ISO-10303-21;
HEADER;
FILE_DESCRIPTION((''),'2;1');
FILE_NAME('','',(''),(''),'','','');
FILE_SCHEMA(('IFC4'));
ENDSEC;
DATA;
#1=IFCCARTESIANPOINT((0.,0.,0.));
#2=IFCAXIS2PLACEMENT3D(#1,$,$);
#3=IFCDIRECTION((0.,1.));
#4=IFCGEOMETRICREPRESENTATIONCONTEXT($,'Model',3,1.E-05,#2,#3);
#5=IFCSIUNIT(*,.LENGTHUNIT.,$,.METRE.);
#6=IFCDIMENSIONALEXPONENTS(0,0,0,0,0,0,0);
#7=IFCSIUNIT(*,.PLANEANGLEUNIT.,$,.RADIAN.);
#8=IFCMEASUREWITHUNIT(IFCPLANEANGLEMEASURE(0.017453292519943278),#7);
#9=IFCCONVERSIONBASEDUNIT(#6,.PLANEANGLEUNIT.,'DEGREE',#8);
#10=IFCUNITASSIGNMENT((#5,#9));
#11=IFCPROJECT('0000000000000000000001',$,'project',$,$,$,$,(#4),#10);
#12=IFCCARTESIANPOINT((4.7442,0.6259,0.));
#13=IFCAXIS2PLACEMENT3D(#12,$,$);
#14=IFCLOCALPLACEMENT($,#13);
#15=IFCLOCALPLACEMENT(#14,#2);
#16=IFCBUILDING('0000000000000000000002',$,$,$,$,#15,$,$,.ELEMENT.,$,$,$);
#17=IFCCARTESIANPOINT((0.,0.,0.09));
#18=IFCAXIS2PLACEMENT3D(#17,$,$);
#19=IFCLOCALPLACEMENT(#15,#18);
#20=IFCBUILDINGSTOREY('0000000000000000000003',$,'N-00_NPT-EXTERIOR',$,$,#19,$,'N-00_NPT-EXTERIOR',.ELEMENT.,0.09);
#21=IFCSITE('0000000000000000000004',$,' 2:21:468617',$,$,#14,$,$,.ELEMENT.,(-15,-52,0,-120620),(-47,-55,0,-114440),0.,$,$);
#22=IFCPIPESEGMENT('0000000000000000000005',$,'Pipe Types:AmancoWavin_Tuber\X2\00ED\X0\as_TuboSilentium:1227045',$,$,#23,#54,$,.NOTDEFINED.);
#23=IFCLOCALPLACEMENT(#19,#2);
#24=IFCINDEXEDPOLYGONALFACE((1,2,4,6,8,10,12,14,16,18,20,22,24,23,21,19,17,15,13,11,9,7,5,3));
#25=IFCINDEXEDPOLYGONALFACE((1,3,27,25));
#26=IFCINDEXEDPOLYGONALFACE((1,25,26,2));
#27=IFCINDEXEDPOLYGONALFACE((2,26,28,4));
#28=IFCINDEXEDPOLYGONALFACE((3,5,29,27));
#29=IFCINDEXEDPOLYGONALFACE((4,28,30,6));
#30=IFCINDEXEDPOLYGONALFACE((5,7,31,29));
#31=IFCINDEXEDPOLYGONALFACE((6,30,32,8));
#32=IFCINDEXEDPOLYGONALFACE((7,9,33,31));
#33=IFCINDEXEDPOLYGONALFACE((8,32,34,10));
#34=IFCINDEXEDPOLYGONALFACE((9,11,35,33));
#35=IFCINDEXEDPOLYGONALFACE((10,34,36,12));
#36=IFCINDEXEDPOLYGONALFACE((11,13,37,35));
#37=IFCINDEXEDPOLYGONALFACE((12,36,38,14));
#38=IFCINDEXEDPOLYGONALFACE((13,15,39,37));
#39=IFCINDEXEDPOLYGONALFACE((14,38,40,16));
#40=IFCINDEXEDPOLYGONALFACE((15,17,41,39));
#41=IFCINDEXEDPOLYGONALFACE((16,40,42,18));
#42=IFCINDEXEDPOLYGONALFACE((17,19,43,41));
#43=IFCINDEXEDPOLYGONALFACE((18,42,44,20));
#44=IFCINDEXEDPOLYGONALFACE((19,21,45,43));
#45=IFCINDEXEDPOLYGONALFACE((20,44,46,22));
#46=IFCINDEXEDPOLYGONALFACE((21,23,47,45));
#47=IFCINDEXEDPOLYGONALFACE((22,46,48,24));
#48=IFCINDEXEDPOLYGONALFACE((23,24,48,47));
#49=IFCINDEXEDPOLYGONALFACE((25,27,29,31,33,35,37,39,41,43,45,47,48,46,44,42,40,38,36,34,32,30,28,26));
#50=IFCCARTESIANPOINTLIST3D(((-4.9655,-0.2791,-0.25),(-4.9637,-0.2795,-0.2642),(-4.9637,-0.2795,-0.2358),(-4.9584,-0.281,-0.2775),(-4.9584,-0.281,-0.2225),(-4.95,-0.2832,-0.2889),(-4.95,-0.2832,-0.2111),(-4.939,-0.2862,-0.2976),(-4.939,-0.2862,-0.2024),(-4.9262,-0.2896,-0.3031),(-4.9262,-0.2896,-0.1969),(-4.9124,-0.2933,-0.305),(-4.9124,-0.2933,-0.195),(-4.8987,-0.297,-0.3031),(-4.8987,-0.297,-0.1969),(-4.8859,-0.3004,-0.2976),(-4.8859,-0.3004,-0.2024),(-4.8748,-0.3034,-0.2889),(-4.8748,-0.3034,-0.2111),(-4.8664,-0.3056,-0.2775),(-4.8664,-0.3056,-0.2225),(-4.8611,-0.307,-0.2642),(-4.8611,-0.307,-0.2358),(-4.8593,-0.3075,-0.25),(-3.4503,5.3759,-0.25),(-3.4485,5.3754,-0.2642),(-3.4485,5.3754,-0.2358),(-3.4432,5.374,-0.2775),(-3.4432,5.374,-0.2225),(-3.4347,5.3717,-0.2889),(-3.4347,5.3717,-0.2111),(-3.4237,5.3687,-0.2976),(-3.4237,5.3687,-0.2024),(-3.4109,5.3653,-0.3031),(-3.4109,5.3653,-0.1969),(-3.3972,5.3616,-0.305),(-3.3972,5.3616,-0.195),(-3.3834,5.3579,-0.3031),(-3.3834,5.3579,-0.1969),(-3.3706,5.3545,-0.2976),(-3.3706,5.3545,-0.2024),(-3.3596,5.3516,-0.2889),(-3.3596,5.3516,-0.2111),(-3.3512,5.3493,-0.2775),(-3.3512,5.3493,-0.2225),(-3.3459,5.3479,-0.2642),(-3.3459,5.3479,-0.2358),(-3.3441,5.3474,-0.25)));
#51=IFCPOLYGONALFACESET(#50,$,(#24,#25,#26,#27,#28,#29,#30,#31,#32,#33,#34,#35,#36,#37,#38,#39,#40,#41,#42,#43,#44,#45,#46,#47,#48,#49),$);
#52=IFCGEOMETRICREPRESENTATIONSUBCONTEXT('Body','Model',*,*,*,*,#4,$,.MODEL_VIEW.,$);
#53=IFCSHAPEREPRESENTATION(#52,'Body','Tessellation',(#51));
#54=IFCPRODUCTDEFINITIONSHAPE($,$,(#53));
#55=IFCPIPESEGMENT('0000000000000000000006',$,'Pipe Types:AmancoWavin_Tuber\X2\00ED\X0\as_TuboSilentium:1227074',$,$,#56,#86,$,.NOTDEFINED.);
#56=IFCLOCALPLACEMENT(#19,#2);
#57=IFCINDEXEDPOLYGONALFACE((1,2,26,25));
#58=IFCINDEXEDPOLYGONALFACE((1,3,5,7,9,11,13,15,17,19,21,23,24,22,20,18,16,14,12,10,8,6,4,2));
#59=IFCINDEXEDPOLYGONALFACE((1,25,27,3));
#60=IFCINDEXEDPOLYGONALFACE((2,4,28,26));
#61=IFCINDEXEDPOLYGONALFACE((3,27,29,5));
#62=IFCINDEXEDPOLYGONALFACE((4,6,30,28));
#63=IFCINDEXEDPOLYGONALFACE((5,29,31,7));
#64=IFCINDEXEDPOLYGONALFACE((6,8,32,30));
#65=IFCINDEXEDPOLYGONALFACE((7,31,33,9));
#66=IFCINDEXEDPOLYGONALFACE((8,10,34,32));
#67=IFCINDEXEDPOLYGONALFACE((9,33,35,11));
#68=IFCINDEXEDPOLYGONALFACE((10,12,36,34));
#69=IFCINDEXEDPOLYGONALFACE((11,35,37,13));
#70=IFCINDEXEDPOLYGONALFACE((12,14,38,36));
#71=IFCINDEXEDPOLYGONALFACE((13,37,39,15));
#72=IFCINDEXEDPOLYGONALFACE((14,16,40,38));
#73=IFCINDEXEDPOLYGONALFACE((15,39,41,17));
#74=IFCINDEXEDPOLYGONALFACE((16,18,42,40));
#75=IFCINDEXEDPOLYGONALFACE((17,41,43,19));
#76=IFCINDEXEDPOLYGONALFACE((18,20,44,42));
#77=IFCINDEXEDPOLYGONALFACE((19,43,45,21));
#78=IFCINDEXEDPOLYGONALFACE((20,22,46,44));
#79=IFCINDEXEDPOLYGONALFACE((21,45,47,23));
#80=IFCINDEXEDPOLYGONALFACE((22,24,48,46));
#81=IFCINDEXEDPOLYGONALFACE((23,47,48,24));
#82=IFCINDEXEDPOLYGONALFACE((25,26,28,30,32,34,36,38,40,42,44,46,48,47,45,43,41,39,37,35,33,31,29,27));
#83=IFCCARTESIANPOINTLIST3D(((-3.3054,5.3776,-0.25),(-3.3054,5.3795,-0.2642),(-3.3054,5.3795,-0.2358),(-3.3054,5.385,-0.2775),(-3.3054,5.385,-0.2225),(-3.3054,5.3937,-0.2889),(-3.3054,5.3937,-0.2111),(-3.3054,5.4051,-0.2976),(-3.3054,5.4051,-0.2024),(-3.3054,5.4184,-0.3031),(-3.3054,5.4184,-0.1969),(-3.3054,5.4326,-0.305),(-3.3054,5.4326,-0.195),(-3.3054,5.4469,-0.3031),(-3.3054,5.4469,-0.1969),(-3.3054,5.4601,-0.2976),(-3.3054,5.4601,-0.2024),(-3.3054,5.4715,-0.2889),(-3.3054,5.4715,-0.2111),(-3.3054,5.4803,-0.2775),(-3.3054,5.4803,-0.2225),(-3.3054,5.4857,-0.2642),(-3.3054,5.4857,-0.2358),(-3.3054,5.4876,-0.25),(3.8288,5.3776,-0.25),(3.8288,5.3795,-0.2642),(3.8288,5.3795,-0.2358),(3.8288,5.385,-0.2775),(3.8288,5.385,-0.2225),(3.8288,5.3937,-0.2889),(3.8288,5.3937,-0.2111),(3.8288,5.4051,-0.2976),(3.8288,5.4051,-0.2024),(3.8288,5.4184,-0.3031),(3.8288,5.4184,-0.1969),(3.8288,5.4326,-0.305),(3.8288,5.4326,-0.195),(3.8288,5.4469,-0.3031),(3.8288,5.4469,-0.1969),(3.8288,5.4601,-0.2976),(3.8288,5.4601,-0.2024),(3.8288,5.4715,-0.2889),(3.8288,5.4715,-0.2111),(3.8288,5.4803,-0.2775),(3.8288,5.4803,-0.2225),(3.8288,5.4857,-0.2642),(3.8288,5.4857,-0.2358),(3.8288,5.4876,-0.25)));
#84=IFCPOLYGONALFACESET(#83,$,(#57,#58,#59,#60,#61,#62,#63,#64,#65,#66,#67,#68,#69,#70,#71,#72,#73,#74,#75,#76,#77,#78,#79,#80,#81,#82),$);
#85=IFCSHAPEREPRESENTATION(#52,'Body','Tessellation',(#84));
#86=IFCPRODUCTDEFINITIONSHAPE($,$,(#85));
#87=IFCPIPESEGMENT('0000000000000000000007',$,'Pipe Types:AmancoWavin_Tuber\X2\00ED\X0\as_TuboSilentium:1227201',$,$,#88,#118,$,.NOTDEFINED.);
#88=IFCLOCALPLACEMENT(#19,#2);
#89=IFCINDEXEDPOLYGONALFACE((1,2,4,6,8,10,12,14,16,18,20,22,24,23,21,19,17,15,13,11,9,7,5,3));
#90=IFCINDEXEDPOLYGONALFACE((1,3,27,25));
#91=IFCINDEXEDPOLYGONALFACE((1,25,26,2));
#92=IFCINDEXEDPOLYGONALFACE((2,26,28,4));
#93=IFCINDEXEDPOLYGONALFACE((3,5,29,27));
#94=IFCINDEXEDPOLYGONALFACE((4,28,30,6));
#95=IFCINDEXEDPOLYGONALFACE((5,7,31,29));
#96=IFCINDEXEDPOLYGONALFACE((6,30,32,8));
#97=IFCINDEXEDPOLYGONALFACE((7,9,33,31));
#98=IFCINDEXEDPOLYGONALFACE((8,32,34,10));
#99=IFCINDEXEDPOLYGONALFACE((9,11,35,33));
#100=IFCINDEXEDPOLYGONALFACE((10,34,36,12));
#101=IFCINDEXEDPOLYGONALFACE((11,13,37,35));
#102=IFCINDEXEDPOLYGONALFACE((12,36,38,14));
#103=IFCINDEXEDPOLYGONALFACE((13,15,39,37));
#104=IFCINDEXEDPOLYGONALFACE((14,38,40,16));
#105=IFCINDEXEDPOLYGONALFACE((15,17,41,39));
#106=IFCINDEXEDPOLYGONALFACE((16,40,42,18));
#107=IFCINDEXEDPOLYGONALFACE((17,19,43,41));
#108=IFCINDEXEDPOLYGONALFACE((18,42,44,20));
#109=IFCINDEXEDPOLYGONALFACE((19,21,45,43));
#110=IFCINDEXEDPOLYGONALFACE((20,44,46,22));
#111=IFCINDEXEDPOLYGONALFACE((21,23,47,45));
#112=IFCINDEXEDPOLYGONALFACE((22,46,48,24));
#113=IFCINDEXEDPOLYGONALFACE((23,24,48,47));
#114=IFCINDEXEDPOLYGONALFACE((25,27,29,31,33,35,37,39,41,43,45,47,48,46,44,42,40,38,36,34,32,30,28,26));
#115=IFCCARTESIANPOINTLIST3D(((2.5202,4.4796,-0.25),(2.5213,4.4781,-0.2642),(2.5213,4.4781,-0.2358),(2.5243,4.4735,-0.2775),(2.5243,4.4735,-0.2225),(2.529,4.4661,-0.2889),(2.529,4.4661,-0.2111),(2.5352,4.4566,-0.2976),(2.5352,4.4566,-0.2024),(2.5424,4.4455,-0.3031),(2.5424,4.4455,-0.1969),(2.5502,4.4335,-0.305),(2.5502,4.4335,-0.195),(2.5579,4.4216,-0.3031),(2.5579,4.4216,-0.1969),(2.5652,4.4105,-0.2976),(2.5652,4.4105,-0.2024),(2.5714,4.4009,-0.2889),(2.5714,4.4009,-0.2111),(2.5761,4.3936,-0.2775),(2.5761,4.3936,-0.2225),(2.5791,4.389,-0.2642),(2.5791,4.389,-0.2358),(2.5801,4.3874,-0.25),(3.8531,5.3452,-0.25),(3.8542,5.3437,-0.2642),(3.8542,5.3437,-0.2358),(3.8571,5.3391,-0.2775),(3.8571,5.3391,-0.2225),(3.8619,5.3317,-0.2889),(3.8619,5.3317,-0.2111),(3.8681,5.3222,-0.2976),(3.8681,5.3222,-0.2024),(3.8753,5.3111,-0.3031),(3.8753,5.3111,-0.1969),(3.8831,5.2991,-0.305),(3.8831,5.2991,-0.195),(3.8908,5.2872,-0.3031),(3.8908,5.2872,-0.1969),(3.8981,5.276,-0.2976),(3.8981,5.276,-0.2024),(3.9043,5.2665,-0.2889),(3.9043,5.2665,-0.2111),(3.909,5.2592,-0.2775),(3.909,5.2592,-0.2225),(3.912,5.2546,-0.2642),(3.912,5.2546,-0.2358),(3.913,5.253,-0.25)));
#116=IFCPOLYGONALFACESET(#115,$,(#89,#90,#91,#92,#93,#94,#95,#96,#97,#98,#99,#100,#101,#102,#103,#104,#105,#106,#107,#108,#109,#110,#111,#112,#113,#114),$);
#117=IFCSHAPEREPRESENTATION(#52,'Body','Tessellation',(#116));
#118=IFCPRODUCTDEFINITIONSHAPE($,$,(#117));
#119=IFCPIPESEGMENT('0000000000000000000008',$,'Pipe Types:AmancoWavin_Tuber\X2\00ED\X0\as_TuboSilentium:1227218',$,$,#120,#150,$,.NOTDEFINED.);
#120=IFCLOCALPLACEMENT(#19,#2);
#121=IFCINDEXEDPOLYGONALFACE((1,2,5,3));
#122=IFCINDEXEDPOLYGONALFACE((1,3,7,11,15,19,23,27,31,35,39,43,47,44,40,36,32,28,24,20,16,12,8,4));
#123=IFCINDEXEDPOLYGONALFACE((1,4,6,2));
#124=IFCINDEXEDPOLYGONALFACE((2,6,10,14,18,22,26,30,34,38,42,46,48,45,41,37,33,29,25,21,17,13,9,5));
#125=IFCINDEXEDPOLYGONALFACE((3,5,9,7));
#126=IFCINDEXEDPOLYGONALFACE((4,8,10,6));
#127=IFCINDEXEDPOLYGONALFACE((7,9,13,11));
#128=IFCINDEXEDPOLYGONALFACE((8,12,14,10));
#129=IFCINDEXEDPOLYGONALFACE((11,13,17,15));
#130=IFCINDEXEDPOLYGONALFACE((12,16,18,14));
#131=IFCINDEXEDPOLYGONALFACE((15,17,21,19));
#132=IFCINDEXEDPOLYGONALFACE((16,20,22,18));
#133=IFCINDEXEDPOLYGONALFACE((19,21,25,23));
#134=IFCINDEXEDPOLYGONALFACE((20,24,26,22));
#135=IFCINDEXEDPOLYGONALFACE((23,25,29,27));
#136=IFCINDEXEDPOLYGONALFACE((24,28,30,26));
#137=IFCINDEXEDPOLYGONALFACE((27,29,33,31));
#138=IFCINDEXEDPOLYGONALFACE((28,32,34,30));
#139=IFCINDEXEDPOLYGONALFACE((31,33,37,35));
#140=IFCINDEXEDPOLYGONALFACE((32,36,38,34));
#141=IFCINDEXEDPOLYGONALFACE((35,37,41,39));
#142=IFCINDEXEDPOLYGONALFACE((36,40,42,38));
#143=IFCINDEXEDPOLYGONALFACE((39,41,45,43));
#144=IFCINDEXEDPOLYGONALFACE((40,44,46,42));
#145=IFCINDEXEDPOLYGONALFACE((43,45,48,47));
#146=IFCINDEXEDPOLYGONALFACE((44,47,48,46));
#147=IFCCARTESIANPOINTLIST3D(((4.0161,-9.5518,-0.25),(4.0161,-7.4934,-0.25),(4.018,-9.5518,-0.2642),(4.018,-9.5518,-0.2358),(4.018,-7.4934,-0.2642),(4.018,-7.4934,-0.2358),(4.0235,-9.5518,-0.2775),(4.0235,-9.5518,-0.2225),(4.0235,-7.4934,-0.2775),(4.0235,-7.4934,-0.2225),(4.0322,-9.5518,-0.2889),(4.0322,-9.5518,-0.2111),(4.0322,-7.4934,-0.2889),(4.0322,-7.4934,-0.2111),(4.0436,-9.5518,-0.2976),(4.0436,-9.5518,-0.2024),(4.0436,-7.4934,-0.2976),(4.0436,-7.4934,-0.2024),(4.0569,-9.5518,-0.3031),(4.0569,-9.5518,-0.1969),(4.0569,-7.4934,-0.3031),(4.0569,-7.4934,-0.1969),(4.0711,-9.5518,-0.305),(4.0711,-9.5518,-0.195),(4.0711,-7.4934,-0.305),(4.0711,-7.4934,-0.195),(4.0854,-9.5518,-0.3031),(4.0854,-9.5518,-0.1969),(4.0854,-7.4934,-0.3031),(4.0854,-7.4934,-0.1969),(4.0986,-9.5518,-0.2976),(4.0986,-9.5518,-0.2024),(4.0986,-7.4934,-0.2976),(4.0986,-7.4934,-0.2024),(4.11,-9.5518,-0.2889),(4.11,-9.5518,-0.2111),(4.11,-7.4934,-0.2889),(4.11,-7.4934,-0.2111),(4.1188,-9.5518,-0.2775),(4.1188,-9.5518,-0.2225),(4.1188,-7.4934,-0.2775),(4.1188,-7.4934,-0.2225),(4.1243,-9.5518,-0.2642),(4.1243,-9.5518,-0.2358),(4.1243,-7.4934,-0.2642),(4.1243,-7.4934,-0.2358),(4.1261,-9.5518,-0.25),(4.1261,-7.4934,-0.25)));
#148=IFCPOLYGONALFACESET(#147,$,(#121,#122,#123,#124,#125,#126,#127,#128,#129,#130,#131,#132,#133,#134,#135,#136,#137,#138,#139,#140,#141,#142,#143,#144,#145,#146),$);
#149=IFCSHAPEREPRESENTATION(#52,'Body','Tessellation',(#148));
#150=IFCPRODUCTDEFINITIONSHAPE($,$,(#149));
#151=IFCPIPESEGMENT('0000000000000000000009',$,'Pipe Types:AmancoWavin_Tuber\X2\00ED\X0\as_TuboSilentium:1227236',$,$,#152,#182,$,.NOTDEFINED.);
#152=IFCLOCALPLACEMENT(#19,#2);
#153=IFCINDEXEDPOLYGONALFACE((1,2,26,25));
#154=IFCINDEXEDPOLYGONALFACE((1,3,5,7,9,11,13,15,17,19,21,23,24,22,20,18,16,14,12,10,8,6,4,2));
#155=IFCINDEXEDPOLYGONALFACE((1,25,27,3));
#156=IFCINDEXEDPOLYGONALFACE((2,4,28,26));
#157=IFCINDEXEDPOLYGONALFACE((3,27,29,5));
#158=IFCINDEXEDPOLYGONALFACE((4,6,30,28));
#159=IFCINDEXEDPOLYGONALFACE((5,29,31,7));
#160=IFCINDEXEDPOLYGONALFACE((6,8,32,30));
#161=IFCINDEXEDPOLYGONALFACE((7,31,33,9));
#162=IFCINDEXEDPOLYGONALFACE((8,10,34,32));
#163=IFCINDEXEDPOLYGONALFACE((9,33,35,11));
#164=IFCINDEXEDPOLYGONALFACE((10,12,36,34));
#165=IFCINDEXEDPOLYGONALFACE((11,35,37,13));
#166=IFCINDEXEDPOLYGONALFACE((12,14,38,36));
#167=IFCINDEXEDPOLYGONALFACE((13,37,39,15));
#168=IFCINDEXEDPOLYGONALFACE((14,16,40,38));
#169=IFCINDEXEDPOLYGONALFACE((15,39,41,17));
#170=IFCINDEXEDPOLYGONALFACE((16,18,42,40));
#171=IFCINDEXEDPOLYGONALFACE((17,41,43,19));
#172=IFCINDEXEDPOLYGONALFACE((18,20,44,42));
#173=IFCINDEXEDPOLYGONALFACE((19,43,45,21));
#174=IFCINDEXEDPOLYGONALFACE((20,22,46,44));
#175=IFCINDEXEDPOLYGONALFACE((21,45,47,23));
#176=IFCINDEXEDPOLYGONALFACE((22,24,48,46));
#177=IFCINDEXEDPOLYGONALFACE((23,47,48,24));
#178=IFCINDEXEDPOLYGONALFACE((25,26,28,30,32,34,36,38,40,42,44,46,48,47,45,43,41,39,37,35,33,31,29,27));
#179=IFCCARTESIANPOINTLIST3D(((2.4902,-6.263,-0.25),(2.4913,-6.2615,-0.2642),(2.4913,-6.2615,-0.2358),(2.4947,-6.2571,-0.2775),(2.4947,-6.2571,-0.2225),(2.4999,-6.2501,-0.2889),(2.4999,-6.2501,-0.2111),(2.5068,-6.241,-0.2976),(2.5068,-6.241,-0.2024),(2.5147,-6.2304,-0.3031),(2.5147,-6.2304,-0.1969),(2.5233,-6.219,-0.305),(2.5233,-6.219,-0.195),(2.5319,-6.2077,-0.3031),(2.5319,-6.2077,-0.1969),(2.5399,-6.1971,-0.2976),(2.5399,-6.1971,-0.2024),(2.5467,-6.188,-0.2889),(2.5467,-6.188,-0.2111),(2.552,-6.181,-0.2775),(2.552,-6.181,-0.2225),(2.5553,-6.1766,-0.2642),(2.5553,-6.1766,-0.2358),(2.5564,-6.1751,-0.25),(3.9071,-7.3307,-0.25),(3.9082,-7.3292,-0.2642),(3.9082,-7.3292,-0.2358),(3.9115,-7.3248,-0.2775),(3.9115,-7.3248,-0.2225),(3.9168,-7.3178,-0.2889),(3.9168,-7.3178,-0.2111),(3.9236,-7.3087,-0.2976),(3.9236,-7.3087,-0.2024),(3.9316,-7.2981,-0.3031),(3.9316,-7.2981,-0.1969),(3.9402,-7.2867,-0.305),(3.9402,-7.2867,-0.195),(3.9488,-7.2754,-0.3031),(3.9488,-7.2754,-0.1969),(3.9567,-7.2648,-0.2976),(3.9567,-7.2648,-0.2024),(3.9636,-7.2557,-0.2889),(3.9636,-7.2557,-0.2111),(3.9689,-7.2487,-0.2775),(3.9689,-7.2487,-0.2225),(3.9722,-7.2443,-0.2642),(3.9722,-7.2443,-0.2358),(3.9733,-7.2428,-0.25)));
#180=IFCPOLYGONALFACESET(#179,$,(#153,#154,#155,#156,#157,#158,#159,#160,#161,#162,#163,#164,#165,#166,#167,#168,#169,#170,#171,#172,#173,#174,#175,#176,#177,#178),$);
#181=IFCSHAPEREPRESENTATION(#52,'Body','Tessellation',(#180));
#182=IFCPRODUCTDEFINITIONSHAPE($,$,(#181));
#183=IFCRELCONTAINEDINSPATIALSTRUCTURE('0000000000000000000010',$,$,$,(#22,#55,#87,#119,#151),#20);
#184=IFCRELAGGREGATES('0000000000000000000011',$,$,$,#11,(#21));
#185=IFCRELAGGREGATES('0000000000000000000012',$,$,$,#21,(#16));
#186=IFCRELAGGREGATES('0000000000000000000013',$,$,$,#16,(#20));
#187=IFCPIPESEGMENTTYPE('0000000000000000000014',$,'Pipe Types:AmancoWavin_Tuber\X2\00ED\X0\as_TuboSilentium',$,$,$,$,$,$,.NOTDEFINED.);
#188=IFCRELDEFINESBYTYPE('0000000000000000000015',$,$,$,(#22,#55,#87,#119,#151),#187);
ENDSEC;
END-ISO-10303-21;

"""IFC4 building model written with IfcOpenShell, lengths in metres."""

from ifc_helpers import new_model, entity, si_unit, converted_unit, direction, frame, origin, place, context, subcontext, project, spatial, arc, indexed_curve, outline, extrude, type_object, element, save


model = new_model("IFC4")

# Units and contexts
model_context = context("Model", 3, precision=1e-05, world=origin(), true_north=direction((0.0, 1.0)))
body_context = subcontext(model_context, "Body", "Model", "MODEL_VIEW")
ifc_project = project(units=[si_unit("LENGTHUNIT", "METRE"), converted_unit("PLANEANGLEUNIT", "DEGREE", entity("IfcPlaneAngleMeasure", 0.017453292519943278), si_unit("PLANEANGLEUNIT", "RADIAN"), dimensions=[0, 0, 0, 0, 0, 0, 0])], contexts=[model_context])

# Site, building, storey
site_placement = place(None, frame((4.7442, 0.6259, 0.0)))
site = spatial("IfcSite", under=ifc_project, at=site_placement, Name=" 2:21:468617", CompositionType="ELEMENT", RefLatitude=(-15, -52, 0, -120620), RefLongitude=(-47, -55, 0, -114440), RefElevation=0.0)
building_placement = place(site_placement, origin())
building = spatial("IfcBuilding", under=site, at=building_placement, CompositionType="ELEMENT")
storey_placement = place(building_placement, frame((0.0, 0.0, 0.09)))
storey = spatial("IfcBuildingStorey", under=building, at=storey_placement, Name="N-00_NPT-EXTERIOR", LongName="N-00_NPT-EXTERIOR", CompositionType="ELEMENT", Elevation=0.09)

# Pipe segments
pipe_segment_type_1 = type_object("IfcPipeSegmentType", Name="Pipe Types:AmancoWavin_Tuberías_TuboSilentium", PredefinedType="NOTDEFINED")
pipe_segment_1_placement = place(storey_placement, origin())
element("IfcPipeSegment", 1, at=pipe_segment_1_placement, inside=storey, type_object=pipe_segment_type_1, Name="Pipe Types:AmancoWavin_Tuberías_TuboSilentium:1227045", PredefinedType="NOTDEFINED", context=body_context, shape_type="SweptSolid", body=[
    extrude(outline(indexed_curve([(0.055, 0.0), (0.0389, 0.0389), (0.0, 0.055), (-0.0389, 0.0389), (-0.055, 0.0), (-0.0389, -0.0389), (0.0, -0.055), (0.0389, -0.0389)], segments=[arc(1, 2, 3), arc(3, 4, 5), arc(5, 6, 7), arc(7, 8, 1)], self_intersect=False)), frame((-4.9124, -0.2933, -0.25), z_axis=(0.258819, 0.965926, 0.0), x_axis=(0.965926, -0.258819, 0.0)), (0.0, 0.0, 1.0), 5.8544),
])
pipe_segment_2_placement = place(storey_placement, origin())
element("IfcPipeSegment", 2, at=pipe_segment_2_placement, inside=storey, type_object=pipe_segment_type_1, Name="Pipe Types:AmancoWavin_Tuberías_TuboSilentium:1227074", PredefinedType="NOTDEFINED", context=body_context, shape_type="SweptSolid", body=[
    extrude(outline(indexed_curve([(0.055, 0.0), (0.0389, 0.0389), (0.0, 0.055), (-0.0389, 0.0389), (-0.055, 0.0), (-0.0389, -0.0389), (0.0, -0.055), (0.0389, -0.0389)], segments=[arc(1, 2, 3), arc(3, 4, 5), arc(5, 6, 7), arc(7, 8, 1)], self_intersect=False)), frame((-3.3054, 5.4326, -0.25), z_axis=(1.0, 0.0, 0.0), x_axis=(0.0, -1.0, 0.0)), (0.0, 0.0, 1.0), 7.1342),
])
pipe_segment_3_placement = place(storey_placement, origin())
element("IfcPipeSegment", 3, at=pipe_segment_3_placement, inside=storey, type_object=pipe_segment_type_1, Name="Pipe Types:AmancoWavin_Tuberías_TuboSilentium:1227201", PredefinedType="NOTDEFINED", context=body_context, shape_type="SweptSolid", body=[
    extrude(outline(indexed_curve([(0.055, 0.0), (0.0389, 0.0389), (0.0, 0.055), (-0.0389, 0.0389), (-0.055, 0.0), (-0.0389, -0.0389), (0.0, -0.055), (0.0389, -0.0389)], segments=[arc(1, 2, 3), arc(3, 4, 5), arc(5, 6, 7), arc(7, 8, 1)], self_intersect=False)), frame((2.5502, 4.4335, -0.25), z_axis=(0.838671, 0.544639, 0.0), x_axis=(0.544639, -0.838671, 0.0)), (0.0, 0.0, 1.0), 1.5893),
])
pipe_segment_4_placement = place(storey_placement, origin())
element("IfcPipeSegment", 4, at=pipe_segment_4_placement, inside=storey, type_object=pipe_segment_type_1, Name="Pipe Types:AmancoWavin_Tuberías_TuboSilentium:1227218", PredefinedType="NOTDEFINED", context=body_context, shape_type="SweptSolid", body=[
    extrude(outline(indexed_curve([(0.055, 0.0), (0.0389, 0.0389), (0.0, 0.055), (-0.0389, 0.0389), (-0.055, 0.0), (-0.0389, -0.0389), (0.0, -0.055), (0.0389, -0.0389)], segments=[arc(1, 2, 3), arc(3, 4, 5), arc(5, 6, 7), arc(7, 8, 1)], self_intersect=False)), frame((4.0711, -9.5518, -0.25), z_axis=(0.0, 1.0, 0.0), x_axis=(-1.0, 0.0, 0.0)), (0.0, 0.0, 1.0), 2.0584),
])
pipe_segment_5_placement = place(storey_placement, origin())
element("IfcPipeSegment", 5, at=pipe_segment_5_placement, inside=storey, type_object=pipe_segment_type_1, Name="Pipe Types:AmancoWavin_Tuberías_TuboSilentium:1227236", PredefinedType="NOTDEFINED", context=body_context, shape_type="SweptSolid", body=[
    extrude(outline(indexed_curve([(0.055, 0.0), (0.0389, 0.0389), (0.0, 0.055), (-0.0389, 0.0389), (-0.055, 0.0), (-0.0389, -0.0389), (0.0, -0.055), (0.0389, -0.0389)], segments=[arc(1, 2, 3), arc(3, 4, 5), arc(5, 6, 7), arc(7, 8, 1)], self_intersect=False)), frame((2.5233, -6.219, -0.25), z_axis=(0.798636, -0.601815, 0.0), x_axis=(-0.601815, -0.798636, 0.0)), (0.0, 0.0, 1.0), 1.7741),
])

save(model, "model.ifc")
